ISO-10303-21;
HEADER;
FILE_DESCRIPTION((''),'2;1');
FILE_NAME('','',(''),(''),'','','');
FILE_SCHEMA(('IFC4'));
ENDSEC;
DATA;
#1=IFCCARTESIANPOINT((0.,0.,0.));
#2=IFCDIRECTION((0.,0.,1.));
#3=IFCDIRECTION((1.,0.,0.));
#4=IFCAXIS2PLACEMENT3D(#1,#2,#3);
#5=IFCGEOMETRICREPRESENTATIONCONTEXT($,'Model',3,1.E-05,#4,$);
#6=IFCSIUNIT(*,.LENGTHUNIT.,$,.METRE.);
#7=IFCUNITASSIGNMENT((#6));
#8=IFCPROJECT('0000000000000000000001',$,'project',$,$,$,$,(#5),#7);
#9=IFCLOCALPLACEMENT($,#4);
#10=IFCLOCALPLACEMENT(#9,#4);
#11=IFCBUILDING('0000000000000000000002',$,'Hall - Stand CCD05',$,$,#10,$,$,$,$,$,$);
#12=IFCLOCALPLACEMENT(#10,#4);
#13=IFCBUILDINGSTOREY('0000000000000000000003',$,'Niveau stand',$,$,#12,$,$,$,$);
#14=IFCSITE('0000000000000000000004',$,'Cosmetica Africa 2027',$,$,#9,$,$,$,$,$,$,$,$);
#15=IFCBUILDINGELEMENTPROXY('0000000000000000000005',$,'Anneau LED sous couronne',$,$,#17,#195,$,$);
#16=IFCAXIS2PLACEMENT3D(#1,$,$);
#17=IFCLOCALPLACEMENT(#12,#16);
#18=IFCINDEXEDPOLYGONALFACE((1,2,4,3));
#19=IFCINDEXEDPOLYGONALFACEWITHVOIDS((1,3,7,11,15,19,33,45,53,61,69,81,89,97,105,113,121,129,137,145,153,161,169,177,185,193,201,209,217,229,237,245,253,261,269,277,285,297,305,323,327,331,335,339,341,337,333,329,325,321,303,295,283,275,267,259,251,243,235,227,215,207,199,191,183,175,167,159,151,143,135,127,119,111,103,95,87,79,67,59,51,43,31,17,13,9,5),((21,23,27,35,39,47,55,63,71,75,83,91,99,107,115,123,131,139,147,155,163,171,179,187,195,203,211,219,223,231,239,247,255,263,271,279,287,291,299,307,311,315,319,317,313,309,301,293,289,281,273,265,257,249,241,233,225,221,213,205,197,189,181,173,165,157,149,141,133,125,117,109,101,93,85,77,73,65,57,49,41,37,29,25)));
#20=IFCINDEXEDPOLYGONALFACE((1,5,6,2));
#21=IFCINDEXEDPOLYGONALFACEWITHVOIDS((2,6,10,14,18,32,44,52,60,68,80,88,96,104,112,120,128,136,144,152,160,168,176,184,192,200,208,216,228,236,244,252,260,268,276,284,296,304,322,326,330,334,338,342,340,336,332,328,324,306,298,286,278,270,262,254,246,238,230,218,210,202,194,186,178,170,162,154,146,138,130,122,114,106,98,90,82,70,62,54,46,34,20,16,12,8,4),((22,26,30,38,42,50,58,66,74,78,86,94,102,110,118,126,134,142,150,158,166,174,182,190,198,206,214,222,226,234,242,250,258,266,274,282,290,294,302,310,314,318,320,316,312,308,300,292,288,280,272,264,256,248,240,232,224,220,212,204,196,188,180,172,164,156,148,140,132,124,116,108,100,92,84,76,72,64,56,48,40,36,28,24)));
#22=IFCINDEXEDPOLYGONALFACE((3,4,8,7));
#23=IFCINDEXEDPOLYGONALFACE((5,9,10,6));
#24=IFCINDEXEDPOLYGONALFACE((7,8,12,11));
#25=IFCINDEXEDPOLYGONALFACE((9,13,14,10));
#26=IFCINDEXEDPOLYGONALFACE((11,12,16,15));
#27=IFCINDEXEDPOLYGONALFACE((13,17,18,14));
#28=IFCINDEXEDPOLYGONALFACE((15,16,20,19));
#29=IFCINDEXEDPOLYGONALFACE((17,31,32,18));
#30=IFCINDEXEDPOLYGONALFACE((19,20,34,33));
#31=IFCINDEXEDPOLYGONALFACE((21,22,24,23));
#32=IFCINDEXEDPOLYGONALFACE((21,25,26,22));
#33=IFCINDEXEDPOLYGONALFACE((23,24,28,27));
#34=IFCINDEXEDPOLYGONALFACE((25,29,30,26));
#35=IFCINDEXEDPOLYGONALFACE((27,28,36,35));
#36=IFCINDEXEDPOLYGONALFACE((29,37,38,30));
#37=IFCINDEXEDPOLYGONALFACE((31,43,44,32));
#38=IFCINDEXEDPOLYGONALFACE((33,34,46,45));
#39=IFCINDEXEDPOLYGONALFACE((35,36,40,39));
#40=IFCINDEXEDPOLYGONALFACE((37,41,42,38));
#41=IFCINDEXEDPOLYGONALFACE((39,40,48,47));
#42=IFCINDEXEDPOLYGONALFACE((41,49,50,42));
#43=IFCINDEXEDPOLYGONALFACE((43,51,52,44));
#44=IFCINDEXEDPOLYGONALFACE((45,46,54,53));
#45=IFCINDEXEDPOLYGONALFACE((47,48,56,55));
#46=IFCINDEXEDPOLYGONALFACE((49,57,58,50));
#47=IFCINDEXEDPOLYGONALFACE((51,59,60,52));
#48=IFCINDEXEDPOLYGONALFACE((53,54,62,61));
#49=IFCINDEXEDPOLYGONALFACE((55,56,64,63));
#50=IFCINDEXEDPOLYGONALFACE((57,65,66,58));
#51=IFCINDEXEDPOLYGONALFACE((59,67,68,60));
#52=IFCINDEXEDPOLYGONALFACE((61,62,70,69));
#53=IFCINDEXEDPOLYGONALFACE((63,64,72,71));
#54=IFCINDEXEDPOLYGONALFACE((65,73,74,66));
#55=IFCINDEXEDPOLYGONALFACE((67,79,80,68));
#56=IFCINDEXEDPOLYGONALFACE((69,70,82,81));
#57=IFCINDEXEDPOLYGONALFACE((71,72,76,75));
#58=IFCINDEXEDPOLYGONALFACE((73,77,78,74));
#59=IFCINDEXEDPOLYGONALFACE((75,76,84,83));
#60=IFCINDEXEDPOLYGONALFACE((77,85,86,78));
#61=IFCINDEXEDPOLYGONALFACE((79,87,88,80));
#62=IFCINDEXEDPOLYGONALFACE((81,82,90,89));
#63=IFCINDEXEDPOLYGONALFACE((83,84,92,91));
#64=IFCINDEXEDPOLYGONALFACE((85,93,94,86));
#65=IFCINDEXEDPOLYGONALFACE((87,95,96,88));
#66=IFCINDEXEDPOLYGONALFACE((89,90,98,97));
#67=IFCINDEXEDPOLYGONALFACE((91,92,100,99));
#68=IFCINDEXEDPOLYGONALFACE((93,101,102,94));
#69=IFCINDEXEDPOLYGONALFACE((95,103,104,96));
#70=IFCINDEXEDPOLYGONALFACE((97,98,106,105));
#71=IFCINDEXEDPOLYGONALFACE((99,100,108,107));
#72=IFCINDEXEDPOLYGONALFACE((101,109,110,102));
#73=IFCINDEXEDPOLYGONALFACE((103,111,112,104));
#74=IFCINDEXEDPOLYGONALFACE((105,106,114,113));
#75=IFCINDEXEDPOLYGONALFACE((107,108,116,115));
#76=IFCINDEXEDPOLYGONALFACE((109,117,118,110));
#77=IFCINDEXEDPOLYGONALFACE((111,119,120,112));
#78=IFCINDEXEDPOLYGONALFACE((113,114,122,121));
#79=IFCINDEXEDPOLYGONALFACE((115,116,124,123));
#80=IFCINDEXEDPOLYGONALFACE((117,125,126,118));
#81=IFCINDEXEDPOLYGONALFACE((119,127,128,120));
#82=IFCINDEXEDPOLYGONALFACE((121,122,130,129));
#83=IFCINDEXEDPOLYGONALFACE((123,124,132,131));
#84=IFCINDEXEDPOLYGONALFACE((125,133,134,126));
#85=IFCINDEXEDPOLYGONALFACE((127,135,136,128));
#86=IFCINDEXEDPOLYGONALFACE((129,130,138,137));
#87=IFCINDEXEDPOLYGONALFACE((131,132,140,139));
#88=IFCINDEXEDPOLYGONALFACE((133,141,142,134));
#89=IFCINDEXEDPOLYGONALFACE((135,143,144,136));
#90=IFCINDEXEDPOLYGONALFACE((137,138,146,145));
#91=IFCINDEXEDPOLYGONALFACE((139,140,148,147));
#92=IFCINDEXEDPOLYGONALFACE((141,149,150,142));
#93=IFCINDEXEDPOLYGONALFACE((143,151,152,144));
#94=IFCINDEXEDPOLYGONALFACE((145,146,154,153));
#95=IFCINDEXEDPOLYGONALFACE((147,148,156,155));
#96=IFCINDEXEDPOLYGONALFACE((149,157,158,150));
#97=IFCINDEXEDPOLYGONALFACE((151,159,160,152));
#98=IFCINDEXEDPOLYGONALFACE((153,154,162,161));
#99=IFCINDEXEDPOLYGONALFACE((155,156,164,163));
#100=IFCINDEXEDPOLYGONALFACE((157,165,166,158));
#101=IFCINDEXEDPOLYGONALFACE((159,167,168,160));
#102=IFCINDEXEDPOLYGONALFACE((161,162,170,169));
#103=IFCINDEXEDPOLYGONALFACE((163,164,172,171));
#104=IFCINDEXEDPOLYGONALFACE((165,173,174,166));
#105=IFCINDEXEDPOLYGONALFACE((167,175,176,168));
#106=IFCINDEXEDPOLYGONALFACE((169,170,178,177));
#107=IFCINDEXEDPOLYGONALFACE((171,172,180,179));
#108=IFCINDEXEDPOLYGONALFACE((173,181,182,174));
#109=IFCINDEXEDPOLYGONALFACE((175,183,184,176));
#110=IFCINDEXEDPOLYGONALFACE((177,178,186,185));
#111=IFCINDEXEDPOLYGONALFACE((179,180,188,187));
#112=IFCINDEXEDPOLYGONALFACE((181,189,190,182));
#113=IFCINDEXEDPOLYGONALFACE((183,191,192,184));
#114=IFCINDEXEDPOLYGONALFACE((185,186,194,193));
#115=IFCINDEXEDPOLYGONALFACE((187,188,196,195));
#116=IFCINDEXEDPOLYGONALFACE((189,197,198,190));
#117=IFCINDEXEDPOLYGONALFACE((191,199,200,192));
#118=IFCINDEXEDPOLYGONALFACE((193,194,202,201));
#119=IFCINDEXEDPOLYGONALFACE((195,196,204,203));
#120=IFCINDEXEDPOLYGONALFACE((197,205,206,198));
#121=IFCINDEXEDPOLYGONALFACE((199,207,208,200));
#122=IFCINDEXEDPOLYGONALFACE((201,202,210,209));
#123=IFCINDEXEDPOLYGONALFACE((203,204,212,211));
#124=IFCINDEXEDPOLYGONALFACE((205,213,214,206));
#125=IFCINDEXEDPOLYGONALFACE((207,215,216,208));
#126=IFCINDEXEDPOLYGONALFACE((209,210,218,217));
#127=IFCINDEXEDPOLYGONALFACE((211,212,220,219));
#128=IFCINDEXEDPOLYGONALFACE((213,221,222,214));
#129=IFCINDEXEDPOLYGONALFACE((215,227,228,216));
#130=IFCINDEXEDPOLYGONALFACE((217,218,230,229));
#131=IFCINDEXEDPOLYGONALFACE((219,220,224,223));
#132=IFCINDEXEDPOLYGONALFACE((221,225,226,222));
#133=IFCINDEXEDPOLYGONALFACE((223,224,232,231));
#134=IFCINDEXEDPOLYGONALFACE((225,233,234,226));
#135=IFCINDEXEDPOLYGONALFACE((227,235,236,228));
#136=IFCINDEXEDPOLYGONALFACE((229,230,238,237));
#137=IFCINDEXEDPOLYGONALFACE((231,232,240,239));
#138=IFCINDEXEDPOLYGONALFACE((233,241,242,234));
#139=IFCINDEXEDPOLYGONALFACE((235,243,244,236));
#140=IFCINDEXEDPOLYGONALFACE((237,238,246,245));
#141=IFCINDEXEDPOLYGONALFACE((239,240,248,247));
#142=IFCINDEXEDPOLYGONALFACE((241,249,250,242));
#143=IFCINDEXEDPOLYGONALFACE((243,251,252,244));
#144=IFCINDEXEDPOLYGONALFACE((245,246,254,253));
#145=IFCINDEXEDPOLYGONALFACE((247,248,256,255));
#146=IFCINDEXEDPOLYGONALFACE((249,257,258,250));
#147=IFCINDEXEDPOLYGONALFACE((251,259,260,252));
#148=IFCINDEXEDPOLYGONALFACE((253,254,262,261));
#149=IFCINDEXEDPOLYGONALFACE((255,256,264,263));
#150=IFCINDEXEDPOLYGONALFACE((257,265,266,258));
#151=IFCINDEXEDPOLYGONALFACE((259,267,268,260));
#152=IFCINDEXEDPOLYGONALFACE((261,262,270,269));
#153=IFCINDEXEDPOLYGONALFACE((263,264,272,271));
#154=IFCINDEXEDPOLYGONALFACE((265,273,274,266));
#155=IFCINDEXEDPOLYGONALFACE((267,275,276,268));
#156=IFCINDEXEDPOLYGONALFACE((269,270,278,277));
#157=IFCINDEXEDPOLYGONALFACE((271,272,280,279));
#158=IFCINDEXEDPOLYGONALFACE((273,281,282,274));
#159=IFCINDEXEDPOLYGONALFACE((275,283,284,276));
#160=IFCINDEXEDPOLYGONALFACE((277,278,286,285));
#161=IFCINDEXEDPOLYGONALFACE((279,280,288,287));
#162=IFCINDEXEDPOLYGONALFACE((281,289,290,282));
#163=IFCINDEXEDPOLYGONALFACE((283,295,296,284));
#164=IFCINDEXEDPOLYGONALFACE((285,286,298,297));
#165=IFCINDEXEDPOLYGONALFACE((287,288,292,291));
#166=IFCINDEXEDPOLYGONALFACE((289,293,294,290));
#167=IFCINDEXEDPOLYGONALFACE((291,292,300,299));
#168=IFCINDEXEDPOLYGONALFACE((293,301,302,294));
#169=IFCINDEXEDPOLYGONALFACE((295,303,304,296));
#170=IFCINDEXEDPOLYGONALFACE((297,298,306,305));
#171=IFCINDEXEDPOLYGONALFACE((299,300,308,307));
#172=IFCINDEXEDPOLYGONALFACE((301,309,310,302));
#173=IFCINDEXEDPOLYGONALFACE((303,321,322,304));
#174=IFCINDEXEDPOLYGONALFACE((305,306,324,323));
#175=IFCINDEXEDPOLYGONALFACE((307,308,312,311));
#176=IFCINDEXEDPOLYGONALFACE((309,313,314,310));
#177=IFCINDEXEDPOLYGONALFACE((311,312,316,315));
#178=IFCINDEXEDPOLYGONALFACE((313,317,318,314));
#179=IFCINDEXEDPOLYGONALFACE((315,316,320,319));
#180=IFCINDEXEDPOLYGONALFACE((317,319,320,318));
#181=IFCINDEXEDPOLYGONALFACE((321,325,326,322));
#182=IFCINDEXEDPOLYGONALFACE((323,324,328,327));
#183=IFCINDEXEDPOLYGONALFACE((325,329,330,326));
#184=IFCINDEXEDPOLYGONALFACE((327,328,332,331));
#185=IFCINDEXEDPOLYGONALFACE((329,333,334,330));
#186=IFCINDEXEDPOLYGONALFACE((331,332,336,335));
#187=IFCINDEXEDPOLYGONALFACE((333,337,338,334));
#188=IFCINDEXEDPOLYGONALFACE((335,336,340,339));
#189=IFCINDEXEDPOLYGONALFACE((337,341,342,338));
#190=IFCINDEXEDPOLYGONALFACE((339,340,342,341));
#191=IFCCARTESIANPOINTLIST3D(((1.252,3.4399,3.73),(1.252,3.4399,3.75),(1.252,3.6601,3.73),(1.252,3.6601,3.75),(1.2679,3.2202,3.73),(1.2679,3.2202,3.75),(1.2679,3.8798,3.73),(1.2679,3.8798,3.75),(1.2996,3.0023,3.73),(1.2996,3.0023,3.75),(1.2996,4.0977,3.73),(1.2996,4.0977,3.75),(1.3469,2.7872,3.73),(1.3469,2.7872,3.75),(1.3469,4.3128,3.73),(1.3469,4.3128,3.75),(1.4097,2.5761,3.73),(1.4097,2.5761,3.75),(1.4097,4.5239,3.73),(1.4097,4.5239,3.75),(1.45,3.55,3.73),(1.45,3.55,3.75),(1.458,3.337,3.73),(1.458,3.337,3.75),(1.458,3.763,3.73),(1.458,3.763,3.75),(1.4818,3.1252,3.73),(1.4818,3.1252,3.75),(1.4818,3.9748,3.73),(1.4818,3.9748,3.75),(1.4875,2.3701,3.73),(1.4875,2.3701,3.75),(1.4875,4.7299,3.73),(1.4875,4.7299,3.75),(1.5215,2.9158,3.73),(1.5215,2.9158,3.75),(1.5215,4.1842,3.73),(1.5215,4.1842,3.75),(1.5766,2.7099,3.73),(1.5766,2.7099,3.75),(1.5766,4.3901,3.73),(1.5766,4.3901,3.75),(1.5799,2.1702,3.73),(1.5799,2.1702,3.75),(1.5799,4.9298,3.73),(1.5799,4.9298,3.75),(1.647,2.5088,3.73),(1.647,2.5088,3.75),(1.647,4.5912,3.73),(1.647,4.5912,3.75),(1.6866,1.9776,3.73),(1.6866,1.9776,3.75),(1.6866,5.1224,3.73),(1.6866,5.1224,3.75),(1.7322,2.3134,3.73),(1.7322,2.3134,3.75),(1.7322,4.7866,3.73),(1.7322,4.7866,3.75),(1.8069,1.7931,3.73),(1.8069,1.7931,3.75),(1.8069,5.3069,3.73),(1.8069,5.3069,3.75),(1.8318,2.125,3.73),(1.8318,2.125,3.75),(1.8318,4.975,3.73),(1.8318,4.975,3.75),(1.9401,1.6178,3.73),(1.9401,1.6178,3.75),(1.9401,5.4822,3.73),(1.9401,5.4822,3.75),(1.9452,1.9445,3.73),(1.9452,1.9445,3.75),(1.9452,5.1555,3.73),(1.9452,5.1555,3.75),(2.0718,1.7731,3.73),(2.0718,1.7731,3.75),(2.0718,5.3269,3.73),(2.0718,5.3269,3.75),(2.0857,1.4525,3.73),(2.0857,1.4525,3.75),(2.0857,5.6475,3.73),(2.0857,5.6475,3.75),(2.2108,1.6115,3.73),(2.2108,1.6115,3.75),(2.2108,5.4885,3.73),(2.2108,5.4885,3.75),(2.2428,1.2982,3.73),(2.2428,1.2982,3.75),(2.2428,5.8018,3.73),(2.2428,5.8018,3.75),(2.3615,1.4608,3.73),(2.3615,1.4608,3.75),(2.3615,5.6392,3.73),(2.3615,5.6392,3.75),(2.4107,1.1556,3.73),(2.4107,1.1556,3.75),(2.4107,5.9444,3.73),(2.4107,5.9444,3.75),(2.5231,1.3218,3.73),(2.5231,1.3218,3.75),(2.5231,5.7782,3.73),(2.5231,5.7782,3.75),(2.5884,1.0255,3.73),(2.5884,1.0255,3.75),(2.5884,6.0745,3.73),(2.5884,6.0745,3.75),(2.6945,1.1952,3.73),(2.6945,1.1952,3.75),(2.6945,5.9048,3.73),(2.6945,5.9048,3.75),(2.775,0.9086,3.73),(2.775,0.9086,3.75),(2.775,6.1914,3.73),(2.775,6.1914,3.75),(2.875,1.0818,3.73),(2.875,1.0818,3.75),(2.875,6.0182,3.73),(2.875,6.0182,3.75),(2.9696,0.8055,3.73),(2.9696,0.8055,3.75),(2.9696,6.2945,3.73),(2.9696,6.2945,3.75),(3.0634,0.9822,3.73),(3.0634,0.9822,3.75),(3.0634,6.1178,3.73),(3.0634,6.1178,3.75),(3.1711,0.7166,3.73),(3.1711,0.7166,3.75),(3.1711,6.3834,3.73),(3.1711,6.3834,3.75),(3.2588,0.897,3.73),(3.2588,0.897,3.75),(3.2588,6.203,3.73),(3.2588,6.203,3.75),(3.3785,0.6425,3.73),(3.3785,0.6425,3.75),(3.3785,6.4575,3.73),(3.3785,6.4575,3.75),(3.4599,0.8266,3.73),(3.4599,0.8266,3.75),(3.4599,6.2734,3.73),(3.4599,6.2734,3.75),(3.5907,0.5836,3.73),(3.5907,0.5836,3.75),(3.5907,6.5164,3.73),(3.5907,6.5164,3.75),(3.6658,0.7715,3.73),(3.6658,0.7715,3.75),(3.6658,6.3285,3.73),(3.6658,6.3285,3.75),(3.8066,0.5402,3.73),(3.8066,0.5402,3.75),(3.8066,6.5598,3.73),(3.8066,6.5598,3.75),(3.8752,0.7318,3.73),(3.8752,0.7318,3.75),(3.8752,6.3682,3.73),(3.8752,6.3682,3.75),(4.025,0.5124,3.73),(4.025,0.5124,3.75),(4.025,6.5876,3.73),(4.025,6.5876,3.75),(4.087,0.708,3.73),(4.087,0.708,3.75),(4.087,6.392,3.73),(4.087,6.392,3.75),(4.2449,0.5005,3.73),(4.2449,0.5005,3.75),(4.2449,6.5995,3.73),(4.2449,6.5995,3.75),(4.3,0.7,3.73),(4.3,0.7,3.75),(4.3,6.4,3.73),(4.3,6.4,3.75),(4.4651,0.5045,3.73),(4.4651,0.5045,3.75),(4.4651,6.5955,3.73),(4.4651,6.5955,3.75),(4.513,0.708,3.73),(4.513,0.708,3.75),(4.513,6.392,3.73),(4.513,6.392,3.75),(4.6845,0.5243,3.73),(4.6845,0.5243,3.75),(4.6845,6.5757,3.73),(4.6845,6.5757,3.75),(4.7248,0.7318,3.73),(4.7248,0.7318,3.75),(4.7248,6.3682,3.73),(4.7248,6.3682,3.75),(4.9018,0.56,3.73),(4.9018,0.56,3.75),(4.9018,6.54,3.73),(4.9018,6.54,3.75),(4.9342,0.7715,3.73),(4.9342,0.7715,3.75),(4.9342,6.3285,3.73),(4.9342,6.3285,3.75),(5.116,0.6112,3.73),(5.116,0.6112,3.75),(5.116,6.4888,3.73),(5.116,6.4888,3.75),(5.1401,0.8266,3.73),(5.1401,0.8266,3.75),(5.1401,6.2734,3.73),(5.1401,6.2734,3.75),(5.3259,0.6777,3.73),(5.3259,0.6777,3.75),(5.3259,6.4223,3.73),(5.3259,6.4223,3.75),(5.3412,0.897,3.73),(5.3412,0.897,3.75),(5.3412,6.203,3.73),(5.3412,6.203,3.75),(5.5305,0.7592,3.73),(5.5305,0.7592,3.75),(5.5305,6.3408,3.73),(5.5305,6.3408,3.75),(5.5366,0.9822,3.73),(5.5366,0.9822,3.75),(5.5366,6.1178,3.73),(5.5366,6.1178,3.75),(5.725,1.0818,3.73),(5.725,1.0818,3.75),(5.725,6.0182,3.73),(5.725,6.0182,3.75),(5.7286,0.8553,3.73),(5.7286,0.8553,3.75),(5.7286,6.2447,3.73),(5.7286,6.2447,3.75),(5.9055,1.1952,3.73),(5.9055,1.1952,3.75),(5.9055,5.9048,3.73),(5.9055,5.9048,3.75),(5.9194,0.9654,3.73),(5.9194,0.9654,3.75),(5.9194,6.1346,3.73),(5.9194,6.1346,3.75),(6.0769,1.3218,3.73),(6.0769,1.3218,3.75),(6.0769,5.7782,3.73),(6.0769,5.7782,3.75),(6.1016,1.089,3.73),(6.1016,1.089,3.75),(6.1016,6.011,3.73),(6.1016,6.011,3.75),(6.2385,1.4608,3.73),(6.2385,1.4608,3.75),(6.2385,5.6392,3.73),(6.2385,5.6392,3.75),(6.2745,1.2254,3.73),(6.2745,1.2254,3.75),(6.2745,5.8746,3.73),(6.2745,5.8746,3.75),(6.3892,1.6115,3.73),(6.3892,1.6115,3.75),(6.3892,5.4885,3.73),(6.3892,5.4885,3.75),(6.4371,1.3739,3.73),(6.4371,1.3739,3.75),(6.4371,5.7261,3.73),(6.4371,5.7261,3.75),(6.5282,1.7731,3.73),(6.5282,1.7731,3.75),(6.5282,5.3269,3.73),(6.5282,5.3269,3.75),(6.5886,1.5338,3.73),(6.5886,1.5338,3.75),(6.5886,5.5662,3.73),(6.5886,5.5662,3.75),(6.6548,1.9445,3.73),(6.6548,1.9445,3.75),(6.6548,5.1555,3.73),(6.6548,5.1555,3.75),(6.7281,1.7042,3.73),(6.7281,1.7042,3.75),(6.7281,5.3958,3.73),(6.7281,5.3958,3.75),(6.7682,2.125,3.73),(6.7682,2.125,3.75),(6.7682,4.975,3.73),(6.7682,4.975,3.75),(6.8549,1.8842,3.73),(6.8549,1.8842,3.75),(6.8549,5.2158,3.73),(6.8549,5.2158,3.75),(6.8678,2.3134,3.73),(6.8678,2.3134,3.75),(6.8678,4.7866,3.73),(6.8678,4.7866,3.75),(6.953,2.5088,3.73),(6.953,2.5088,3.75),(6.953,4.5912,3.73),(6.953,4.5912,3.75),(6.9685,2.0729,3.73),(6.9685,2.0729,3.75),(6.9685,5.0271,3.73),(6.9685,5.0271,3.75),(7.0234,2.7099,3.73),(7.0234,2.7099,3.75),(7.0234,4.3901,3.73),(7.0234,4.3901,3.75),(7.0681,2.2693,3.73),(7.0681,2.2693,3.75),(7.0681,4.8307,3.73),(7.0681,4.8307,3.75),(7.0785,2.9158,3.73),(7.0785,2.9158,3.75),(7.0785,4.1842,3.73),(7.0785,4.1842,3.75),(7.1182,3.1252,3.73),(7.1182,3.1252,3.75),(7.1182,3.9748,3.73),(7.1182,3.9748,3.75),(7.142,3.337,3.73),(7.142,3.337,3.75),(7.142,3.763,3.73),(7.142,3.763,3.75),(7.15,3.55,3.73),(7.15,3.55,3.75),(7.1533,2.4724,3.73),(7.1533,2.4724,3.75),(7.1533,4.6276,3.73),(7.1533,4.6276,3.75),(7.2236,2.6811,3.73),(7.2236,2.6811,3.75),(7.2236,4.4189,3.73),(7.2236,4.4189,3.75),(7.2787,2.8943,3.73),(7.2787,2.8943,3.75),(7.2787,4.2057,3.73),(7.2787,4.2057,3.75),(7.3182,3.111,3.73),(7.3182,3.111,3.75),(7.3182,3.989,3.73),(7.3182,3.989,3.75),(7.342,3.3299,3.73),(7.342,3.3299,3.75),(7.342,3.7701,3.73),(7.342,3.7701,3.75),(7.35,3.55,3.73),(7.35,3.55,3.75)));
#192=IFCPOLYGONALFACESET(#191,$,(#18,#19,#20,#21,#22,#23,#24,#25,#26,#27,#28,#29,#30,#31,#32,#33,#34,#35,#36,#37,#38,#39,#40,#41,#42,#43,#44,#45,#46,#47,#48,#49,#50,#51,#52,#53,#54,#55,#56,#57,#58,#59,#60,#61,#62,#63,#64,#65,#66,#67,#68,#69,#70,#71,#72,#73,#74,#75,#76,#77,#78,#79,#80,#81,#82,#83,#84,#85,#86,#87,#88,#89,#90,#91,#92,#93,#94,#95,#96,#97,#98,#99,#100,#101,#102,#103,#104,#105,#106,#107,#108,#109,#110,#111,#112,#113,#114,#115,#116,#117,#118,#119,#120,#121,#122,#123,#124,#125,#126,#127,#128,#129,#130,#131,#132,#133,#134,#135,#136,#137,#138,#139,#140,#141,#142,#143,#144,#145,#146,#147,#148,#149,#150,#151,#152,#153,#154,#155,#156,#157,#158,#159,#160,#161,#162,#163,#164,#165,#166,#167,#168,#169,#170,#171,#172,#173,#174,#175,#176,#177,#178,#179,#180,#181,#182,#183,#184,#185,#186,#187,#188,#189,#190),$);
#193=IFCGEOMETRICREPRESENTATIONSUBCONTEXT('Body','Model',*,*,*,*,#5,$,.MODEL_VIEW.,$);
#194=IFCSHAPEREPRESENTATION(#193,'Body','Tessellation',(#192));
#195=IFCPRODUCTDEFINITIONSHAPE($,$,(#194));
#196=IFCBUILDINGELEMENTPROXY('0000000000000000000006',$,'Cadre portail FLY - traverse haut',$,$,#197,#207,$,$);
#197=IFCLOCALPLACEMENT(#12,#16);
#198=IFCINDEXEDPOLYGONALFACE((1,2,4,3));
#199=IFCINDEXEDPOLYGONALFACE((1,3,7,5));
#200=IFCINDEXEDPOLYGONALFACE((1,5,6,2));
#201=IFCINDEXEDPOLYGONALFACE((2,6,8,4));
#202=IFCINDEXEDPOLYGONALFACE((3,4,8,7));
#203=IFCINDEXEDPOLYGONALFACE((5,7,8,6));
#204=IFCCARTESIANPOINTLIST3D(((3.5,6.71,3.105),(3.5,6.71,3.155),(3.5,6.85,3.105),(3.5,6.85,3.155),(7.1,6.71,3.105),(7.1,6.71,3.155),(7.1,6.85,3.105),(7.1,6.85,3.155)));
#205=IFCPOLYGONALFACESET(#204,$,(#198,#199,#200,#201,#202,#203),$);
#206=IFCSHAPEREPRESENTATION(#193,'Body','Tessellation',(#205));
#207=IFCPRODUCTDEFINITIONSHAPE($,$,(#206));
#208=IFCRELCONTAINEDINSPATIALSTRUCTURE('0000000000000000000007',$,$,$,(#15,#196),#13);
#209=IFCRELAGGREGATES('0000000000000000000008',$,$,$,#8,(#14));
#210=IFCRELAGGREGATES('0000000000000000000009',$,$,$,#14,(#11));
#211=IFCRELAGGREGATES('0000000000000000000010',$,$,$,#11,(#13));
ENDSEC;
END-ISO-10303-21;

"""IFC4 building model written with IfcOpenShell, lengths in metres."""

from ifc_helpers import new_model, si_unit, frame, frame_2d, origin_with_axes, place, context, subcontext, project, spatial, polyline, hollow_circle, outline, extrude, element, save


model = new_model("IFC4")

# Units and contexts
model_context = context("Model", 3, precision=1e-05, world=origin_with_axes())
body_context = subcontext(model_context, "Body", "Model", "MODEL_VIEW")
ifc_project = project(units=[si_unit("LENGTHUNIT", "METRE")], contexts=[model_context])

# Site, building, storey
site_placement = place(None, origin_with_axes())
site = spatial("IfcSite", under=ifc_project, at=site_placement, Name="Cosmetica Africa 2027")
building_placement = place(site_placement, origin_with_axes())
building = spatial("IfcBuilding", under=site, at=building_placement, Name="Hall - Stand CCD05")
storey_placement = place(building_placement, origin_with_axes())
storey = spatial("IfcBuildingStorey", under=building, at=storey_placement, Name="Niveau stand")

# Building element proxies
proxy_1_placement = place(storey_placement, origin_with_axes())
element("IfcBuildingElementProxy", 1, at=proxy_1_placement, inside=storey, Name="Anneau LED sous couronne", context=body_context, shape_type="SweptSolid", body=[
    extrude(hollow_circle(Radius=3.05, WallThickness=0.2, at=frame_2d((4.3, 3.55))), frame((0.0, 0.0, 3.73)), (0.0, 0.0, 1.0), 0.02),
])
proxy_2_placement = place(storey_placement, origin_with_axes())
element("IfcBuildingElementProxy", 2, at=proxy_2_placement, inside=storey, Name="Cadre portail FLY - traverse haut", context=body_context, shape_type="SweptSolid", body=[
    extrude(outline(polyline([(3.5, 6.71), (7.1, 6.71), (7.1, 6.85), (3.5, 6.85), (3.5, 6.71)])), frame((0.0, 0.0, 3.105)), (0.0, 0.0, 1.0), 0.05),
])

save(model, "model.ifc")
